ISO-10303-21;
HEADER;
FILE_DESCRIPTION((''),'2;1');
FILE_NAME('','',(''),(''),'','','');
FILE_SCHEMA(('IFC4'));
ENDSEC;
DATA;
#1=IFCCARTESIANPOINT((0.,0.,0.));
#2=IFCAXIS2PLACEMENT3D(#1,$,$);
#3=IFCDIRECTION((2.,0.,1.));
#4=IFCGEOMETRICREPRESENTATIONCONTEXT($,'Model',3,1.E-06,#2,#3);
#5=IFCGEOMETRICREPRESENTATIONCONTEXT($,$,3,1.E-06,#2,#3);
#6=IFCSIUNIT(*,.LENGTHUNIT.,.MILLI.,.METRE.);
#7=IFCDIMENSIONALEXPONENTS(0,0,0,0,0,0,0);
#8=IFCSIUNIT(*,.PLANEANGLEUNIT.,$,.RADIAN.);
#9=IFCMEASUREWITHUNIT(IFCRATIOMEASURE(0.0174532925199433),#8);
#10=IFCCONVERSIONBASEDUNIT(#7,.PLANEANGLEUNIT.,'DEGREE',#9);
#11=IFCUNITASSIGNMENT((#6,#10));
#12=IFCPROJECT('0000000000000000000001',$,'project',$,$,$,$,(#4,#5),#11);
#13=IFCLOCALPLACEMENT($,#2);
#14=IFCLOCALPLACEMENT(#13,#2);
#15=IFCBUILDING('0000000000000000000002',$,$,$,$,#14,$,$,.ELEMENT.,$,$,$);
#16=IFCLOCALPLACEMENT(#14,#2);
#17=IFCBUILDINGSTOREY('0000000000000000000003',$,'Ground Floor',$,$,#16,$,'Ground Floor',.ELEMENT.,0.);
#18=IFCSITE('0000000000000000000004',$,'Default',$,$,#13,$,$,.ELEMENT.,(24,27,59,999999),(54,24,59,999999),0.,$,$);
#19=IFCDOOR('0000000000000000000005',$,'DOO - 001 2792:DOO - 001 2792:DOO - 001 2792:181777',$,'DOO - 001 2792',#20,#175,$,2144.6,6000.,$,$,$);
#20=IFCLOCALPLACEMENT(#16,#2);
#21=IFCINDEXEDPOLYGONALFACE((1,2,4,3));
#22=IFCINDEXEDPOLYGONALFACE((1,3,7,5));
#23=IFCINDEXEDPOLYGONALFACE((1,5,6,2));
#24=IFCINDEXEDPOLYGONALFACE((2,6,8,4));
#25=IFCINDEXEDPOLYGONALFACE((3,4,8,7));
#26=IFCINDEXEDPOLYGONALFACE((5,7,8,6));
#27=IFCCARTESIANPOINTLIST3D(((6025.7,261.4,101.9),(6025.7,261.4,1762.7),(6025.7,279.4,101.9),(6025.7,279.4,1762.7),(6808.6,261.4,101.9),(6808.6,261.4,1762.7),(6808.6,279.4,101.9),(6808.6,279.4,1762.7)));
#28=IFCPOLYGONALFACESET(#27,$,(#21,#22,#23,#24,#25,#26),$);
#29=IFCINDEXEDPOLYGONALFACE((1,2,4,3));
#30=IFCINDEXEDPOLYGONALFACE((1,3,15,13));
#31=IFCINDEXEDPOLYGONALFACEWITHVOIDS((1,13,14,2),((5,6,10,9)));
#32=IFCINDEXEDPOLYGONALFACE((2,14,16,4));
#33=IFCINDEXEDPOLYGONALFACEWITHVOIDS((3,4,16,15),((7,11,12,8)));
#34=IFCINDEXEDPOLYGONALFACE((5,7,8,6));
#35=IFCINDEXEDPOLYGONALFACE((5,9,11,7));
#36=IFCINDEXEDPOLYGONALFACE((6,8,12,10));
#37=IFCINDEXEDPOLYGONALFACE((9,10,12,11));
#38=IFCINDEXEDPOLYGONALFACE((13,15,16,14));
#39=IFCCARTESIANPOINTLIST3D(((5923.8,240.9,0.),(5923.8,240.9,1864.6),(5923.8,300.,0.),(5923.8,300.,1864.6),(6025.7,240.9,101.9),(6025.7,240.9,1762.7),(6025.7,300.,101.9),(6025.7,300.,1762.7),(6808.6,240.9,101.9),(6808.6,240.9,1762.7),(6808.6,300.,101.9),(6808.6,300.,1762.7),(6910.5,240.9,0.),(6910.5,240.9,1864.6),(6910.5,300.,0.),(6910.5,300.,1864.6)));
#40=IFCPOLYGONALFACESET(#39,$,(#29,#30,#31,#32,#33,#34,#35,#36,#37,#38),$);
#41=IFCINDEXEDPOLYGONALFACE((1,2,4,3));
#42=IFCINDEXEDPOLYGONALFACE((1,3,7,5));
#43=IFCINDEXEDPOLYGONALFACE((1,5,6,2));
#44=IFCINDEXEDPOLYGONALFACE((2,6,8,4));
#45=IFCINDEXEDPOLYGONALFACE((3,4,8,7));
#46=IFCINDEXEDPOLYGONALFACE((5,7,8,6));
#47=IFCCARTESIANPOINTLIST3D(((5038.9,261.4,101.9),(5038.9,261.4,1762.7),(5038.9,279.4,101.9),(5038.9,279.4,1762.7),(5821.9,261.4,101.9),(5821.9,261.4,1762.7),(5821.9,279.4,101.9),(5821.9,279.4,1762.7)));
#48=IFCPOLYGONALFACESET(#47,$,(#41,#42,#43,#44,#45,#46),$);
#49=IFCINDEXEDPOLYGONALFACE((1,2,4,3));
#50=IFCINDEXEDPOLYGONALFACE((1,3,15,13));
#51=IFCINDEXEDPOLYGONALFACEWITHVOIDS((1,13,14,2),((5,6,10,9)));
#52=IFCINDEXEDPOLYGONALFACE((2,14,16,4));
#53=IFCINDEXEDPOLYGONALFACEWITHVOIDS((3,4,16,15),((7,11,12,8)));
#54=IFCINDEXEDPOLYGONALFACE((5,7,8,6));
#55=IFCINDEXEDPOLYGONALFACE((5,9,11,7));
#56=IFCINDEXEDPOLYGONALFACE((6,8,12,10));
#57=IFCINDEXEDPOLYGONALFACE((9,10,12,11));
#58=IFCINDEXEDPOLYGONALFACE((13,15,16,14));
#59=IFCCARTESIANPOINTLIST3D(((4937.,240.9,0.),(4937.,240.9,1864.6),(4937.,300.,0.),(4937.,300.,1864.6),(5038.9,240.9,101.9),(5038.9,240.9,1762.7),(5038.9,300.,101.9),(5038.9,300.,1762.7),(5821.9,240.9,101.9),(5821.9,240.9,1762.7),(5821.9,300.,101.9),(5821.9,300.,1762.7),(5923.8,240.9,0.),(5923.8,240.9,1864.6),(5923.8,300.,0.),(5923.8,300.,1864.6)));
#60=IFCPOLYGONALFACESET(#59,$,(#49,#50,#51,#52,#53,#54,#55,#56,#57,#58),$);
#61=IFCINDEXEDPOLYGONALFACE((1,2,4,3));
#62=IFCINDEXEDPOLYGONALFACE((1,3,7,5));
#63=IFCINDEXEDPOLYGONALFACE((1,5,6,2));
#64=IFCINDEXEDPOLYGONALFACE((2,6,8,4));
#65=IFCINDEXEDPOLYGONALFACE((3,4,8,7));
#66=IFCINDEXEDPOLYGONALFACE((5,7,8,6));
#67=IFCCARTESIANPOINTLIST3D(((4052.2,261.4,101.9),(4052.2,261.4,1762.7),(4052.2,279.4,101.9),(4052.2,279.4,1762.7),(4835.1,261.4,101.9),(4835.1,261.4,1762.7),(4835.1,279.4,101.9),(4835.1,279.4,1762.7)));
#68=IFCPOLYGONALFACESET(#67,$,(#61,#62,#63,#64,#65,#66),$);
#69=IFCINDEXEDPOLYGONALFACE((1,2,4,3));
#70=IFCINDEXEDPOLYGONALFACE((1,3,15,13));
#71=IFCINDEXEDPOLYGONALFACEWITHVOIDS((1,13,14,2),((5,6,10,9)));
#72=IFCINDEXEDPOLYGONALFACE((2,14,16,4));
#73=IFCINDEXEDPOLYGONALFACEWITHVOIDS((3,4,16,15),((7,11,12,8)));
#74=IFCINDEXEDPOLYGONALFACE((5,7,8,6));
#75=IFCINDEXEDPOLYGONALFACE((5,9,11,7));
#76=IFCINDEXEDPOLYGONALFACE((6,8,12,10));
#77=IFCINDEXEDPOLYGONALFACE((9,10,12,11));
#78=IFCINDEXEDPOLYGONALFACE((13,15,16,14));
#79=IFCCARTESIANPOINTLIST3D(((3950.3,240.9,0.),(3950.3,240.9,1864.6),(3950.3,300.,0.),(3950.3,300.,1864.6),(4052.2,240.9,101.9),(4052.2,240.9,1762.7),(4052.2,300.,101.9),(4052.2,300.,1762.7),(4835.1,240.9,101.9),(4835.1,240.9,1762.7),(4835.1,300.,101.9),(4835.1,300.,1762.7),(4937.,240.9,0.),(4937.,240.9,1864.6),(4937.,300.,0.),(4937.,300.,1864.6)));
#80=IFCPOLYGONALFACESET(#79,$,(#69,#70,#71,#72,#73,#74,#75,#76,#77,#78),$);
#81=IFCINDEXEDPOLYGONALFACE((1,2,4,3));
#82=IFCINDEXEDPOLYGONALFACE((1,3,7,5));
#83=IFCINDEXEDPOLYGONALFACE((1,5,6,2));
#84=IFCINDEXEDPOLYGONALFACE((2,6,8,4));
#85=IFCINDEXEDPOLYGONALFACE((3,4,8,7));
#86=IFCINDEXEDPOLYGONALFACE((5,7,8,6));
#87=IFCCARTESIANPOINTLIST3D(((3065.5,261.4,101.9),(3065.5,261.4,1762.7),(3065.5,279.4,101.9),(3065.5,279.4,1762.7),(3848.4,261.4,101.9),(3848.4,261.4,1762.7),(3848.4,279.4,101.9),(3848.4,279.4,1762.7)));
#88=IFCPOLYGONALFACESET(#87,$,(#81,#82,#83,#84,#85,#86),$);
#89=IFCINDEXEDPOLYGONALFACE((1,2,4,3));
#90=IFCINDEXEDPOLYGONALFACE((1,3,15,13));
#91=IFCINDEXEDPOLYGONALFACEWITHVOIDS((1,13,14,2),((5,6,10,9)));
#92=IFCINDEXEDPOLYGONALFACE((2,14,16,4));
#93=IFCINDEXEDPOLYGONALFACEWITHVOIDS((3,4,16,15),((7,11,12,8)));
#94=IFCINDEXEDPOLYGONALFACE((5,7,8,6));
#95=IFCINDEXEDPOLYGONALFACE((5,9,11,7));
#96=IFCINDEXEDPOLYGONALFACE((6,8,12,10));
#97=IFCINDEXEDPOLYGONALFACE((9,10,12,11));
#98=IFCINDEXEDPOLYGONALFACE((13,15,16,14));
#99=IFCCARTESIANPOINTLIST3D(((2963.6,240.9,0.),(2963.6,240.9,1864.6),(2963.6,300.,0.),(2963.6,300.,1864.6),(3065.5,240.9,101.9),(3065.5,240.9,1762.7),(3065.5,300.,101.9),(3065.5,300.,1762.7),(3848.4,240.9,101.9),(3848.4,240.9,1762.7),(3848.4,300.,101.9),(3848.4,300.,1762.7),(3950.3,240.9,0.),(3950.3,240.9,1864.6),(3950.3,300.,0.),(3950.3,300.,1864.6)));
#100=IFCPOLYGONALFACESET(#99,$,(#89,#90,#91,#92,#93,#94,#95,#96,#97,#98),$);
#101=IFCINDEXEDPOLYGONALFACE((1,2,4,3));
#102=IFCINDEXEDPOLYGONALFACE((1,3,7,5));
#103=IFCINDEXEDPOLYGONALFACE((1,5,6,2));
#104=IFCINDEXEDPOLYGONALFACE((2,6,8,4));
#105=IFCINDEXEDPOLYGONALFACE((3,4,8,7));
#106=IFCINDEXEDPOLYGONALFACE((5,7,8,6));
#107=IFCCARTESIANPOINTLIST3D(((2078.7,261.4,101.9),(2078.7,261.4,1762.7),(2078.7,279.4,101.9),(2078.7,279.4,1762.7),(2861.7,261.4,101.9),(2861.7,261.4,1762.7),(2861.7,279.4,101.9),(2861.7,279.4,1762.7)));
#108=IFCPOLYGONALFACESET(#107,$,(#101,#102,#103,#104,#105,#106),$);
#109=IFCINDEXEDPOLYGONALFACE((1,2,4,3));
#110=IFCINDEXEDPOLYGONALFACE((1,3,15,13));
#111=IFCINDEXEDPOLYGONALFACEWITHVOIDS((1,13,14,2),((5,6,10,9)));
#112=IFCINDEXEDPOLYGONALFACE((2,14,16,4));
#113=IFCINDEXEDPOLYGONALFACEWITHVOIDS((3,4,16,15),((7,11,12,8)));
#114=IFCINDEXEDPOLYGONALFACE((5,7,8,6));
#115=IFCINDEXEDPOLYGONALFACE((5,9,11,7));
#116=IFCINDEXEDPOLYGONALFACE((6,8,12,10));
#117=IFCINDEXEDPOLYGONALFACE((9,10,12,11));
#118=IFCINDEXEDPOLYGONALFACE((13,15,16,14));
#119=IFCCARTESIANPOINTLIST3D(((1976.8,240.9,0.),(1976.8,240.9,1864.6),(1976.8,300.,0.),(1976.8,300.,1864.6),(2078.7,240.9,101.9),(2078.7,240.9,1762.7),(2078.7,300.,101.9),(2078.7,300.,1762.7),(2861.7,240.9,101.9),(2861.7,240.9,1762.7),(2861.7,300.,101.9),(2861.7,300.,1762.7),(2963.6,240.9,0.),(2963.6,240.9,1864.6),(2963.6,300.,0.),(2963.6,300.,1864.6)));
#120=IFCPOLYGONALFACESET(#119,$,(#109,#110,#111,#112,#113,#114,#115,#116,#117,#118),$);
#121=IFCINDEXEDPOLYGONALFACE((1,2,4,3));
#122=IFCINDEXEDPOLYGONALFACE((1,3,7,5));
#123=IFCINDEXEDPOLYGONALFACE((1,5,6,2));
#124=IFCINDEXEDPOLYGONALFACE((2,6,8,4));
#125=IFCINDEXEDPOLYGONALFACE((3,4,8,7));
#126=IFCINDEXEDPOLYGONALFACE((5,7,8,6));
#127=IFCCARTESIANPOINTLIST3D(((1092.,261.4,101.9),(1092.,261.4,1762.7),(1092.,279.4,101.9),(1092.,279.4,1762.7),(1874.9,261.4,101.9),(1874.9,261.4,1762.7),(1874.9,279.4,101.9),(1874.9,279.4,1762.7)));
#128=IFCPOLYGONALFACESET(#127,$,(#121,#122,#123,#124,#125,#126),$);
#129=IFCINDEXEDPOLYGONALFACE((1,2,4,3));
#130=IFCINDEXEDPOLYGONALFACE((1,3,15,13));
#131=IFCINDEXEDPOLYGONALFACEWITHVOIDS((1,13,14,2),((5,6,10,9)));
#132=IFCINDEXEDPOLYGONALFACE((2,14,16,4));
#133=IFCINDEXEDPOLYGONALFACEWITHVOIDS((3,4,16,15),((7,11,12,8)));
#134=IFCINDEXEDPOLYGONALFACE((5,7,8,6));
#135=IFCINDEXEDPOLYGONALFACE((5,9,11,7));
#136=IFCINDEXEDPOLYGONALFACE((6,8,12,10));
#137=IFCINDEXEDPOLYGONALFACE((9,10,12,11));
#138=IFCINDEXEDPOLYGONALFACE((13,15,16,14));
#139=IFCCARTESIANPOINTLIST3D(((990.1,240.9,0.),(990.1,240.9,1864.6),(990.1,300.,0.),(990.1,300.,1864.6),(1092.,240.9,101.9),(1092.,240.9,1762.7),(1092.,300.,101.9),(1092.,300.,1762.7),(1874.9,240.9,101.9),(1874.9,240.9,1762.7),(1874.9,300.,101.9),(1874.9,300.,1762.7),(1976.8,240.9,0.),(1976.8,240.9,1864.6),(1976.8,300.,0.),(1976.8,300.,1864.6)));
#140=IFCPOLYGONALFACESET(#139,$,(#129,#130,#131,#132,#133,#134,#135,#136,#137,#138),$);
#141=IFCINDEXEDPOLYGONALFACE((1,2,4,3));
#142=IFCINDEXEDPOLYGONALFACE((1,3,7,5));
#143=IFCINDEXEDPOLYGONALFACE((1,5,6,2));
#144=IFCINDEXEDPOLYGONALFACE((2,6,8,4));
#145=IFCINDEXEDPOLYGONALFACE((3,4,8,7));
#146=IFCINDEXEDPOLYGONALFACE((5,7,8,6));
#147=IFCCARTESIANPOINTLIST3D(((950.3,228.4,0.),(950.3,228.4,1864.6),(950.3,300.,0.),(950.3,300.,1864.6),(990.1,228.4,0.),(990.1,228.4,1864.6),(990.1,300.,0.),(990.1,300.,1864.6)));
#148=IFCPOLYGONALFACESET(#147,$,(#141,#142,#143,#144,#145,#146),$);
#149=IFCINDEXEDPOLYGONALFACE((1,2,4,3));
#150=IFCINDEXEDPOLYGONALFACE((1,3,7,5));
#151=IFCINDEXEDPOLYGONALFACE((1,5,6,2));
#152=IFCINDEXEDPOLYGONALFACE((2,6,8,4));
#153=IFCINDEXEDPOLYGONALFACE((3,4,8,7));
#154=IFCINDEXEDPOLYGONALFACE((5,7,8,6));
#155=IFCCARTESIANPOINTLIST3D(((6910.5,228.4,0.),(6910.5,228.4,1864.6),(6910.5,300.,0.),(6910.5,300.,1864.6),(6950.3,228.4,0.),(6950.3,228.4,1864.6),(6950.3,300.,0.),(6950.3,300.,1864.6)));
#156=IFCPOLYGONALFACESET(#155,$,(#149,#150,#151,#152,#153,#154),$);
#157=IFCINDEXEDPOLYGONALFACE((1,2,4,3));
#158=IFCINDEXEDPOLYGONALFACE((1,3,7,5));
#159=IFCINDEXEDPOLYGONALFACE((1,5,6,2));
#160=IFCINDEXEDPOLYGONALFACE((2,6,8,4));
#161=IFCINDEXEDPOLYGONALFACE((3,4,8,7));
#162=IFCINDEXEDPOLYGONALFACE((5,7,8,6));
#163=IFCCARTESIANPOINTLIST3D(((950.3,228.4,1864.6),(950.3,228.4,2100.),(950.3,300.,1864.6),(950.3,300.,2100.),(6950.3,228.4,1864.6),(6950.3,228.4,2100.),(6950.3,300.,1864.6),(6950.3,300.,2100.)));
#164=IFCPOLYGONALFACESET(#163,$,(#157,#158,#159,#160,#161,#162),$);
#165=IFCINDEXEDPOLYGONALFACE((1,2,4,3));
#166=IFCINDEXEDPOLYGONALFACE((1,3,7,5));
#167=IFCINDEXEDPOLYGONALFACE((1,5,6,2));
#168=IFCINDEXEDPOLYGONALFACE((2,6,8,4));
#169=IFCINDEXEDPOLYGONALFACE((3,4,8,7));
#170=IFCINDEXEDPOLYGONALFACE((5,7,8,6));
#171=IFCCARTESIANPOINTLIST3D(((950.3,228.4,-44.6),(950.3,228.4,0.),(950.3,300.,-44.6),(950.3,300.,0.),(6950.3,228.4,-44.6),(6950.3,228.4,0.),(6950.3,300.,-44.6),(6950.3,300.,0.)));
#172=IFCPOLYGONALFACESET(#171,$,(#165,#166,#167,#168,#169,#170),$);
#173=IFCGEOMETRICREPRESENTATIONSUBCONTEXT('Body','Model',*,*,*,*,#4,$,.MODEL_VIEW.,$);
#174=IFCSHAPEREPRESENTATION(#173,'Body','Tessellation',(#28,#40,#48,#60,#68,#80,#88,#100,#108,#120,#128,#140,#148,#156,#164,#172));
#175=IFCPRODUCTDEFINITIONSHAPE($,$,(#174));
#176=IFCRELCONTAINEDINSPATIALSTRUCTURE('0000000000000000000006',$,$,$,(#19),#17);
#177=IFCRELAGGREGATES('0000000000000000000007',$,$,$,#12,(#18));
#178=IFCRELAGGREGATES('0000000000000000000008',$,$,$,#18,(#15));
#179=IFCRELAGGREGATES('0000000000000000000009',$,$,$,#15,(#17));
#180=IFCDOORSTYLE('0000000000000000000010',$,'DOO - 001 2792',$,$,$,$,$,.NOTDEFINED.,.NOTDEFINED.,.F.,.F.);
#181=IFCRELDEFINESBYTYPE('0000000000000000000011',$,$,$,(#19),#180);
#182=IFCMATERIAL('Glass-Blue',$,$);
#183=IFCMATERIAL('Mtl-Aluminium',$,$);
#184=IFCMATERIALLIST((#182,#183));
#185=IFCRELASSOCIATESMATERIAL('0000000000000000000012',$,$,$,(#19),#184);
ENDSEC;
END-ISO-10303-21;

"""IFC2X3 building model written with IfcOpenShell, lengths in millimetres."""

from ifc_helpers import new_model, entity, si_unit, converted_unit, direction, frame, frame_2d, origin, place, context, subcontext, project, spatial, polyline, rectangle, outline, extrude, source, transform, mapped, material, material_list, type_object, type_shapes, element, save


model = new_model("IFC2X3")

# Units and contexts
model_context = context("Model", 3, precision=1e-06, world=origin(), true_north=direction((2.0, 0.0, 1.0)))
context_of_model = context(None, 3, precision=1e-06, world=origin(), true_north=direction((2.0, 0.0, 1.0)))
body_context = subcontext(model_context, "Body", "Model", "MODEL_VIEW")
ifc_project = project(units=[si_unit("LENGTHUNIT", "METRE", prefix="MILLI"), converted_unit("PLANEANGLEUNIT", "DEGREE", entity("IfcRatioMeasure", 0.0174532925199433), si_unit("PLANEANGLEUNIT", "RADIAN"), dimensions=[0, 0, 0, 0, 0, 0, 0])], contexts=[model_context, context_of_model])

# Site, building, storey
site_placement = place(None, origin())
site = spatial("IfcSite", under=ifc_project, at=site_placement, Name="Default", CompositionType="ELEMENT", RefLatitude=(24, 27, 59, 999999), RefLongitude=(54, 24, 59, 999999), RefElevation=0.0)
building_placement = place(site_placement, origin())
building = spatial("IfcBuilding", under=site, at=building_placement, CompositionType="ELEMENT")
storey_placement = place(building_placement, origin())
storey = spatial("IfcBuildingStorey", under=building, at=storey_placement, Name="Ground Floor", LongName="Ground Floor", CompositionType="ELEMENT", Elevation=0.0)

# Door
ifc_material_1 = material(Name="Glass-Blue")
ifc_material_2 = material(Name="Mtl-Aluminium")
ifc_material_list = material_list([ifc_material_1, ifc_material_2])
door_style = type_object("IfcDoorStyle", Name="DOO - 001 2792", ConstructionType="NOTDEFINED", OperationType="NOTDEFINED", ParameterTakesPrecedence=False, Sizeable=False)
shared_shape = source(origin(), body_context, "Body", "SweptSolid", [
    extrude(rectangle(XDim=782.9, YDim=18.0, at=frame_2d((0.0, 0.0), x_axis=(1.0, 0.0))), frame((6417.1, 270.4, 101.9), z_axis=(0.0, 0.0, 1.0), x_axis=(-1.0, 0.0, 0.0)), (0.0, 0.0, 1.0), 1660.8),
    extrude(outline(polyline([(-493.4, -932.3), (493.4, -932.3), (493.4, 932.3), (-493.4, 932.3), (-493.4, -932.3)]), holes=[polyline([(391.5, 830.4), (391.5, -830.4), (-391.5, -830.4), (-391.5, 830.4), (391.5, 830.4)])]), frame((6417.1, 240.9, 932.3), z_axis=(0.0, 1.0, 0.0), x_axis=(-1.0, 0.0, 0.0)), (0.0, 0.0, 1.0), 59.1),
    extrude(rectangle(XDim=782.9, YDim=18.0, at=frame_2d((0.0, 0.0), x_axis=(1.0, 0.0))), frame((5430.4, 270.4, 101.9), z_axis=(0.0, 0.0, 1.0), x_axis=(-1.0, 0.0, 0.0)), (0.0, 0.0, 1.0), 1660.8),
    extrude(outline(polyline([(-493.4, -932.3), (493.4, -932.3), (493.4, 932.3), (-493.4, 932.3), (-493.4, -932.3)]), holes=[polyline([(391.5, 830.4), (391.5, -830.4), (-391.5, -830.4), (-391.5, 830.4), (391.5, 830.4)])]), frame((5430.4, 240.9, 932.3), z_axis=(0.0, 1.0, 0.0), x_axis=(-1.0, 0.0, 0.0)), (0.0, 0.0, 1.0), 59.1),
    extrude(rectangle(XDim=782.9, YDim=18.0, at=frame_2d((0.0, 0.0), x_axis=(1.0, 0.0))), frame((4443.7, 270.4, 101.9), z_axis=(0.0, 0.0, 1.0), x_axis=(-1.0, 0.0, 0.0)), (0.0, 0.0, 1.0), 1660.8),
    extrude(outline(polyline([(-493.4, -932.3), (493.4, -932.3), (493.4, 932.3), (-493.4, 932.3), (-493.4, -932.3)]), holes=[polyline([(391.5, 830.4), (391.5, -830.4), (-391.5, -830.4), (-391.5, 830.4), (391.5, 830.4)])]), frame((4443.7, 240.9, 932.3), z_axis=(0.0, 1.0, 0.0), x_axis=(-1.0, 0.0, 0.0)), (0.0, 0.0, 1.0), 59.1),
    extrude(rectangle(XDim=782.9, YDim=18.0, at=frame_2d((0.0, 0.0), x_axis=(1.0, 0.0))), frame((3456.9, 270.4, 101.9), z_axis=(0.0, 0.0, 1.0), x_axis=(-1.0, 0.0, 0.0)), (0.0, 0.0, 1.0), 1660.8),
    extrude(outline(polyline([(-493.4, -932.3), (493.4, -932.3), (493.4, 932.3), (-493.4, 932.3), (-493.4, -932.3)]), holes=[polyline([(391.5, 830.4), (391.5, -830.4), (-391.5, -830.4), (-391.5, 830.4), (391.5, 830.4)])]), frame((3456.9, 240.9, 932.3), z_axis=(0.0, 1.0, 0.0), x_axis=(-1.0, 0.0, 0.0)), (0.0, 0.0, 1.0), 59.1),
    extrude(rectangle(XDim=782.9, YDim=18.0, at=frame_2d((0.0, 0.0), x_axis=(1.0, 0.0))), frame((2470.2, 270.4, 101.9), z_axis=(0.0, 0.0, 1.0), x_axis=(-1.0, 0.0, 0.0)), (0.0, 0.0, 1.0), 1660.8),
    extrude(outline(polyline([(-493.4, -932.3), (493.4, -932.3), (493.4, 932.3), (-493.4, 932.3), (-493.4, -932.3)]), holes=[polyline([(391.5, 830.4), (391.5, -830.4), (-391.5, -830.4), (-391.5, 830.4), (391.5, 830.4)])]), frame((2470.2, 240.9, 932.3), z_axis=(0.0, 1.0, 0.0), x_axis=(-1.0, 0.0, 0.0)), (0.0, 0.0, 1.0), 59.1),
    extrude(rectangle(XDim=782.9, YDim=18.0, at=frame_2d((0.0, 0.0), x_axis=(1.0, 0.0))), frame((1483.5, 270.4, 101.9), z_axis=(0.0, 0.0, 1.0), x_axis=(-1.0, 0.0, 0.0)), (0.0, 0.0, 1.0), 1660.8),
    extrude(outline(polyline([(-493.4, -932.3), (493.4, -932.3), (493.4, 932.3), (-493.4, 932.3), (-493.4, -932.3)]), holes=[polyline([(391.5, 830.4), (391.5, -830.4), (-391.5, -830.4), (-391.5, 830.4), (391.5, 830.4)])]), frame((1483.5, 240.9, 932.3), z_axis=(0.0, 1.0, 0.0), x_axis=(-1.0, 0.0, 0.0)), (0.0, 0.0, 1.0), 59.1),
    extrude(rectangle(XDim=39.8, YDim=71.6, at=frame_2d((0.0, 0.0), x_axis=(1.0, 0.0))), frame((970.2, 264.2, 0.0), z_axis=(0.0, 0.0, 1.0), x_axis=(-1.0, 0.0, 0.0)), (0.0, 0.0, 1.0), 1864.6),
    extrude(rectangle(XDim=39.8, YDim=71.6, at=frame_2d((0.0, 0.0), x_axis=(1.0, 0.0))), frame((6930.4, 264.2, 0.0), z_axis=(0.0, 0.0, 1.0), x_axis=(-1.0, 0.0, 0.0)), (0.0, 0.0, 1.0), 1864.6),
    extrude(rectangle(XDim=6000.0, YDim=71.6, at=frame_2d((0.0, 0.0), x_axis=(1.0, 0.0))), frame((3950.3, 264.2, 1864.6), z_axis=(0.0, 0.0, 1.0), x_axis=(-1.0, 0.0, 0.0)), (0.0, 0.0, 1.0), 235.4),
    extrude(rectangle(XDim=6000.0, YDim=71.6, at=frame_2d((0.0, 0.0), x_axis=(1.0, 0.0))), frame((3950.3, 264.2, -44.6), z_axis=(0.0, 0.0, 1.0), x_axis=(-1.0, 0.0, 0.0)), (0.0, 0.0, 1.0), 44.6),
])
type_shapes(door_style, [shared_shape])
door_placement = place(storey_placement, origin())
element("IfcDoor", 1, at=door_placement, inside=storey, type_object=door_style, material=ifc_material_list, Name="DOO - 001 2792:DOO - 001 2792:DOO - 001 2792:181777", ObjectType="DOO - 001 2792", OverallHeight=2144.6, OverallWidth=6000.0, context=body_context, shape_type="MappedRepresentation", body=[
    mapped(shared_shape, transform((0.0, 0.0, 0.0), scale=1.0)),
])

save(model, "model.ifc")
